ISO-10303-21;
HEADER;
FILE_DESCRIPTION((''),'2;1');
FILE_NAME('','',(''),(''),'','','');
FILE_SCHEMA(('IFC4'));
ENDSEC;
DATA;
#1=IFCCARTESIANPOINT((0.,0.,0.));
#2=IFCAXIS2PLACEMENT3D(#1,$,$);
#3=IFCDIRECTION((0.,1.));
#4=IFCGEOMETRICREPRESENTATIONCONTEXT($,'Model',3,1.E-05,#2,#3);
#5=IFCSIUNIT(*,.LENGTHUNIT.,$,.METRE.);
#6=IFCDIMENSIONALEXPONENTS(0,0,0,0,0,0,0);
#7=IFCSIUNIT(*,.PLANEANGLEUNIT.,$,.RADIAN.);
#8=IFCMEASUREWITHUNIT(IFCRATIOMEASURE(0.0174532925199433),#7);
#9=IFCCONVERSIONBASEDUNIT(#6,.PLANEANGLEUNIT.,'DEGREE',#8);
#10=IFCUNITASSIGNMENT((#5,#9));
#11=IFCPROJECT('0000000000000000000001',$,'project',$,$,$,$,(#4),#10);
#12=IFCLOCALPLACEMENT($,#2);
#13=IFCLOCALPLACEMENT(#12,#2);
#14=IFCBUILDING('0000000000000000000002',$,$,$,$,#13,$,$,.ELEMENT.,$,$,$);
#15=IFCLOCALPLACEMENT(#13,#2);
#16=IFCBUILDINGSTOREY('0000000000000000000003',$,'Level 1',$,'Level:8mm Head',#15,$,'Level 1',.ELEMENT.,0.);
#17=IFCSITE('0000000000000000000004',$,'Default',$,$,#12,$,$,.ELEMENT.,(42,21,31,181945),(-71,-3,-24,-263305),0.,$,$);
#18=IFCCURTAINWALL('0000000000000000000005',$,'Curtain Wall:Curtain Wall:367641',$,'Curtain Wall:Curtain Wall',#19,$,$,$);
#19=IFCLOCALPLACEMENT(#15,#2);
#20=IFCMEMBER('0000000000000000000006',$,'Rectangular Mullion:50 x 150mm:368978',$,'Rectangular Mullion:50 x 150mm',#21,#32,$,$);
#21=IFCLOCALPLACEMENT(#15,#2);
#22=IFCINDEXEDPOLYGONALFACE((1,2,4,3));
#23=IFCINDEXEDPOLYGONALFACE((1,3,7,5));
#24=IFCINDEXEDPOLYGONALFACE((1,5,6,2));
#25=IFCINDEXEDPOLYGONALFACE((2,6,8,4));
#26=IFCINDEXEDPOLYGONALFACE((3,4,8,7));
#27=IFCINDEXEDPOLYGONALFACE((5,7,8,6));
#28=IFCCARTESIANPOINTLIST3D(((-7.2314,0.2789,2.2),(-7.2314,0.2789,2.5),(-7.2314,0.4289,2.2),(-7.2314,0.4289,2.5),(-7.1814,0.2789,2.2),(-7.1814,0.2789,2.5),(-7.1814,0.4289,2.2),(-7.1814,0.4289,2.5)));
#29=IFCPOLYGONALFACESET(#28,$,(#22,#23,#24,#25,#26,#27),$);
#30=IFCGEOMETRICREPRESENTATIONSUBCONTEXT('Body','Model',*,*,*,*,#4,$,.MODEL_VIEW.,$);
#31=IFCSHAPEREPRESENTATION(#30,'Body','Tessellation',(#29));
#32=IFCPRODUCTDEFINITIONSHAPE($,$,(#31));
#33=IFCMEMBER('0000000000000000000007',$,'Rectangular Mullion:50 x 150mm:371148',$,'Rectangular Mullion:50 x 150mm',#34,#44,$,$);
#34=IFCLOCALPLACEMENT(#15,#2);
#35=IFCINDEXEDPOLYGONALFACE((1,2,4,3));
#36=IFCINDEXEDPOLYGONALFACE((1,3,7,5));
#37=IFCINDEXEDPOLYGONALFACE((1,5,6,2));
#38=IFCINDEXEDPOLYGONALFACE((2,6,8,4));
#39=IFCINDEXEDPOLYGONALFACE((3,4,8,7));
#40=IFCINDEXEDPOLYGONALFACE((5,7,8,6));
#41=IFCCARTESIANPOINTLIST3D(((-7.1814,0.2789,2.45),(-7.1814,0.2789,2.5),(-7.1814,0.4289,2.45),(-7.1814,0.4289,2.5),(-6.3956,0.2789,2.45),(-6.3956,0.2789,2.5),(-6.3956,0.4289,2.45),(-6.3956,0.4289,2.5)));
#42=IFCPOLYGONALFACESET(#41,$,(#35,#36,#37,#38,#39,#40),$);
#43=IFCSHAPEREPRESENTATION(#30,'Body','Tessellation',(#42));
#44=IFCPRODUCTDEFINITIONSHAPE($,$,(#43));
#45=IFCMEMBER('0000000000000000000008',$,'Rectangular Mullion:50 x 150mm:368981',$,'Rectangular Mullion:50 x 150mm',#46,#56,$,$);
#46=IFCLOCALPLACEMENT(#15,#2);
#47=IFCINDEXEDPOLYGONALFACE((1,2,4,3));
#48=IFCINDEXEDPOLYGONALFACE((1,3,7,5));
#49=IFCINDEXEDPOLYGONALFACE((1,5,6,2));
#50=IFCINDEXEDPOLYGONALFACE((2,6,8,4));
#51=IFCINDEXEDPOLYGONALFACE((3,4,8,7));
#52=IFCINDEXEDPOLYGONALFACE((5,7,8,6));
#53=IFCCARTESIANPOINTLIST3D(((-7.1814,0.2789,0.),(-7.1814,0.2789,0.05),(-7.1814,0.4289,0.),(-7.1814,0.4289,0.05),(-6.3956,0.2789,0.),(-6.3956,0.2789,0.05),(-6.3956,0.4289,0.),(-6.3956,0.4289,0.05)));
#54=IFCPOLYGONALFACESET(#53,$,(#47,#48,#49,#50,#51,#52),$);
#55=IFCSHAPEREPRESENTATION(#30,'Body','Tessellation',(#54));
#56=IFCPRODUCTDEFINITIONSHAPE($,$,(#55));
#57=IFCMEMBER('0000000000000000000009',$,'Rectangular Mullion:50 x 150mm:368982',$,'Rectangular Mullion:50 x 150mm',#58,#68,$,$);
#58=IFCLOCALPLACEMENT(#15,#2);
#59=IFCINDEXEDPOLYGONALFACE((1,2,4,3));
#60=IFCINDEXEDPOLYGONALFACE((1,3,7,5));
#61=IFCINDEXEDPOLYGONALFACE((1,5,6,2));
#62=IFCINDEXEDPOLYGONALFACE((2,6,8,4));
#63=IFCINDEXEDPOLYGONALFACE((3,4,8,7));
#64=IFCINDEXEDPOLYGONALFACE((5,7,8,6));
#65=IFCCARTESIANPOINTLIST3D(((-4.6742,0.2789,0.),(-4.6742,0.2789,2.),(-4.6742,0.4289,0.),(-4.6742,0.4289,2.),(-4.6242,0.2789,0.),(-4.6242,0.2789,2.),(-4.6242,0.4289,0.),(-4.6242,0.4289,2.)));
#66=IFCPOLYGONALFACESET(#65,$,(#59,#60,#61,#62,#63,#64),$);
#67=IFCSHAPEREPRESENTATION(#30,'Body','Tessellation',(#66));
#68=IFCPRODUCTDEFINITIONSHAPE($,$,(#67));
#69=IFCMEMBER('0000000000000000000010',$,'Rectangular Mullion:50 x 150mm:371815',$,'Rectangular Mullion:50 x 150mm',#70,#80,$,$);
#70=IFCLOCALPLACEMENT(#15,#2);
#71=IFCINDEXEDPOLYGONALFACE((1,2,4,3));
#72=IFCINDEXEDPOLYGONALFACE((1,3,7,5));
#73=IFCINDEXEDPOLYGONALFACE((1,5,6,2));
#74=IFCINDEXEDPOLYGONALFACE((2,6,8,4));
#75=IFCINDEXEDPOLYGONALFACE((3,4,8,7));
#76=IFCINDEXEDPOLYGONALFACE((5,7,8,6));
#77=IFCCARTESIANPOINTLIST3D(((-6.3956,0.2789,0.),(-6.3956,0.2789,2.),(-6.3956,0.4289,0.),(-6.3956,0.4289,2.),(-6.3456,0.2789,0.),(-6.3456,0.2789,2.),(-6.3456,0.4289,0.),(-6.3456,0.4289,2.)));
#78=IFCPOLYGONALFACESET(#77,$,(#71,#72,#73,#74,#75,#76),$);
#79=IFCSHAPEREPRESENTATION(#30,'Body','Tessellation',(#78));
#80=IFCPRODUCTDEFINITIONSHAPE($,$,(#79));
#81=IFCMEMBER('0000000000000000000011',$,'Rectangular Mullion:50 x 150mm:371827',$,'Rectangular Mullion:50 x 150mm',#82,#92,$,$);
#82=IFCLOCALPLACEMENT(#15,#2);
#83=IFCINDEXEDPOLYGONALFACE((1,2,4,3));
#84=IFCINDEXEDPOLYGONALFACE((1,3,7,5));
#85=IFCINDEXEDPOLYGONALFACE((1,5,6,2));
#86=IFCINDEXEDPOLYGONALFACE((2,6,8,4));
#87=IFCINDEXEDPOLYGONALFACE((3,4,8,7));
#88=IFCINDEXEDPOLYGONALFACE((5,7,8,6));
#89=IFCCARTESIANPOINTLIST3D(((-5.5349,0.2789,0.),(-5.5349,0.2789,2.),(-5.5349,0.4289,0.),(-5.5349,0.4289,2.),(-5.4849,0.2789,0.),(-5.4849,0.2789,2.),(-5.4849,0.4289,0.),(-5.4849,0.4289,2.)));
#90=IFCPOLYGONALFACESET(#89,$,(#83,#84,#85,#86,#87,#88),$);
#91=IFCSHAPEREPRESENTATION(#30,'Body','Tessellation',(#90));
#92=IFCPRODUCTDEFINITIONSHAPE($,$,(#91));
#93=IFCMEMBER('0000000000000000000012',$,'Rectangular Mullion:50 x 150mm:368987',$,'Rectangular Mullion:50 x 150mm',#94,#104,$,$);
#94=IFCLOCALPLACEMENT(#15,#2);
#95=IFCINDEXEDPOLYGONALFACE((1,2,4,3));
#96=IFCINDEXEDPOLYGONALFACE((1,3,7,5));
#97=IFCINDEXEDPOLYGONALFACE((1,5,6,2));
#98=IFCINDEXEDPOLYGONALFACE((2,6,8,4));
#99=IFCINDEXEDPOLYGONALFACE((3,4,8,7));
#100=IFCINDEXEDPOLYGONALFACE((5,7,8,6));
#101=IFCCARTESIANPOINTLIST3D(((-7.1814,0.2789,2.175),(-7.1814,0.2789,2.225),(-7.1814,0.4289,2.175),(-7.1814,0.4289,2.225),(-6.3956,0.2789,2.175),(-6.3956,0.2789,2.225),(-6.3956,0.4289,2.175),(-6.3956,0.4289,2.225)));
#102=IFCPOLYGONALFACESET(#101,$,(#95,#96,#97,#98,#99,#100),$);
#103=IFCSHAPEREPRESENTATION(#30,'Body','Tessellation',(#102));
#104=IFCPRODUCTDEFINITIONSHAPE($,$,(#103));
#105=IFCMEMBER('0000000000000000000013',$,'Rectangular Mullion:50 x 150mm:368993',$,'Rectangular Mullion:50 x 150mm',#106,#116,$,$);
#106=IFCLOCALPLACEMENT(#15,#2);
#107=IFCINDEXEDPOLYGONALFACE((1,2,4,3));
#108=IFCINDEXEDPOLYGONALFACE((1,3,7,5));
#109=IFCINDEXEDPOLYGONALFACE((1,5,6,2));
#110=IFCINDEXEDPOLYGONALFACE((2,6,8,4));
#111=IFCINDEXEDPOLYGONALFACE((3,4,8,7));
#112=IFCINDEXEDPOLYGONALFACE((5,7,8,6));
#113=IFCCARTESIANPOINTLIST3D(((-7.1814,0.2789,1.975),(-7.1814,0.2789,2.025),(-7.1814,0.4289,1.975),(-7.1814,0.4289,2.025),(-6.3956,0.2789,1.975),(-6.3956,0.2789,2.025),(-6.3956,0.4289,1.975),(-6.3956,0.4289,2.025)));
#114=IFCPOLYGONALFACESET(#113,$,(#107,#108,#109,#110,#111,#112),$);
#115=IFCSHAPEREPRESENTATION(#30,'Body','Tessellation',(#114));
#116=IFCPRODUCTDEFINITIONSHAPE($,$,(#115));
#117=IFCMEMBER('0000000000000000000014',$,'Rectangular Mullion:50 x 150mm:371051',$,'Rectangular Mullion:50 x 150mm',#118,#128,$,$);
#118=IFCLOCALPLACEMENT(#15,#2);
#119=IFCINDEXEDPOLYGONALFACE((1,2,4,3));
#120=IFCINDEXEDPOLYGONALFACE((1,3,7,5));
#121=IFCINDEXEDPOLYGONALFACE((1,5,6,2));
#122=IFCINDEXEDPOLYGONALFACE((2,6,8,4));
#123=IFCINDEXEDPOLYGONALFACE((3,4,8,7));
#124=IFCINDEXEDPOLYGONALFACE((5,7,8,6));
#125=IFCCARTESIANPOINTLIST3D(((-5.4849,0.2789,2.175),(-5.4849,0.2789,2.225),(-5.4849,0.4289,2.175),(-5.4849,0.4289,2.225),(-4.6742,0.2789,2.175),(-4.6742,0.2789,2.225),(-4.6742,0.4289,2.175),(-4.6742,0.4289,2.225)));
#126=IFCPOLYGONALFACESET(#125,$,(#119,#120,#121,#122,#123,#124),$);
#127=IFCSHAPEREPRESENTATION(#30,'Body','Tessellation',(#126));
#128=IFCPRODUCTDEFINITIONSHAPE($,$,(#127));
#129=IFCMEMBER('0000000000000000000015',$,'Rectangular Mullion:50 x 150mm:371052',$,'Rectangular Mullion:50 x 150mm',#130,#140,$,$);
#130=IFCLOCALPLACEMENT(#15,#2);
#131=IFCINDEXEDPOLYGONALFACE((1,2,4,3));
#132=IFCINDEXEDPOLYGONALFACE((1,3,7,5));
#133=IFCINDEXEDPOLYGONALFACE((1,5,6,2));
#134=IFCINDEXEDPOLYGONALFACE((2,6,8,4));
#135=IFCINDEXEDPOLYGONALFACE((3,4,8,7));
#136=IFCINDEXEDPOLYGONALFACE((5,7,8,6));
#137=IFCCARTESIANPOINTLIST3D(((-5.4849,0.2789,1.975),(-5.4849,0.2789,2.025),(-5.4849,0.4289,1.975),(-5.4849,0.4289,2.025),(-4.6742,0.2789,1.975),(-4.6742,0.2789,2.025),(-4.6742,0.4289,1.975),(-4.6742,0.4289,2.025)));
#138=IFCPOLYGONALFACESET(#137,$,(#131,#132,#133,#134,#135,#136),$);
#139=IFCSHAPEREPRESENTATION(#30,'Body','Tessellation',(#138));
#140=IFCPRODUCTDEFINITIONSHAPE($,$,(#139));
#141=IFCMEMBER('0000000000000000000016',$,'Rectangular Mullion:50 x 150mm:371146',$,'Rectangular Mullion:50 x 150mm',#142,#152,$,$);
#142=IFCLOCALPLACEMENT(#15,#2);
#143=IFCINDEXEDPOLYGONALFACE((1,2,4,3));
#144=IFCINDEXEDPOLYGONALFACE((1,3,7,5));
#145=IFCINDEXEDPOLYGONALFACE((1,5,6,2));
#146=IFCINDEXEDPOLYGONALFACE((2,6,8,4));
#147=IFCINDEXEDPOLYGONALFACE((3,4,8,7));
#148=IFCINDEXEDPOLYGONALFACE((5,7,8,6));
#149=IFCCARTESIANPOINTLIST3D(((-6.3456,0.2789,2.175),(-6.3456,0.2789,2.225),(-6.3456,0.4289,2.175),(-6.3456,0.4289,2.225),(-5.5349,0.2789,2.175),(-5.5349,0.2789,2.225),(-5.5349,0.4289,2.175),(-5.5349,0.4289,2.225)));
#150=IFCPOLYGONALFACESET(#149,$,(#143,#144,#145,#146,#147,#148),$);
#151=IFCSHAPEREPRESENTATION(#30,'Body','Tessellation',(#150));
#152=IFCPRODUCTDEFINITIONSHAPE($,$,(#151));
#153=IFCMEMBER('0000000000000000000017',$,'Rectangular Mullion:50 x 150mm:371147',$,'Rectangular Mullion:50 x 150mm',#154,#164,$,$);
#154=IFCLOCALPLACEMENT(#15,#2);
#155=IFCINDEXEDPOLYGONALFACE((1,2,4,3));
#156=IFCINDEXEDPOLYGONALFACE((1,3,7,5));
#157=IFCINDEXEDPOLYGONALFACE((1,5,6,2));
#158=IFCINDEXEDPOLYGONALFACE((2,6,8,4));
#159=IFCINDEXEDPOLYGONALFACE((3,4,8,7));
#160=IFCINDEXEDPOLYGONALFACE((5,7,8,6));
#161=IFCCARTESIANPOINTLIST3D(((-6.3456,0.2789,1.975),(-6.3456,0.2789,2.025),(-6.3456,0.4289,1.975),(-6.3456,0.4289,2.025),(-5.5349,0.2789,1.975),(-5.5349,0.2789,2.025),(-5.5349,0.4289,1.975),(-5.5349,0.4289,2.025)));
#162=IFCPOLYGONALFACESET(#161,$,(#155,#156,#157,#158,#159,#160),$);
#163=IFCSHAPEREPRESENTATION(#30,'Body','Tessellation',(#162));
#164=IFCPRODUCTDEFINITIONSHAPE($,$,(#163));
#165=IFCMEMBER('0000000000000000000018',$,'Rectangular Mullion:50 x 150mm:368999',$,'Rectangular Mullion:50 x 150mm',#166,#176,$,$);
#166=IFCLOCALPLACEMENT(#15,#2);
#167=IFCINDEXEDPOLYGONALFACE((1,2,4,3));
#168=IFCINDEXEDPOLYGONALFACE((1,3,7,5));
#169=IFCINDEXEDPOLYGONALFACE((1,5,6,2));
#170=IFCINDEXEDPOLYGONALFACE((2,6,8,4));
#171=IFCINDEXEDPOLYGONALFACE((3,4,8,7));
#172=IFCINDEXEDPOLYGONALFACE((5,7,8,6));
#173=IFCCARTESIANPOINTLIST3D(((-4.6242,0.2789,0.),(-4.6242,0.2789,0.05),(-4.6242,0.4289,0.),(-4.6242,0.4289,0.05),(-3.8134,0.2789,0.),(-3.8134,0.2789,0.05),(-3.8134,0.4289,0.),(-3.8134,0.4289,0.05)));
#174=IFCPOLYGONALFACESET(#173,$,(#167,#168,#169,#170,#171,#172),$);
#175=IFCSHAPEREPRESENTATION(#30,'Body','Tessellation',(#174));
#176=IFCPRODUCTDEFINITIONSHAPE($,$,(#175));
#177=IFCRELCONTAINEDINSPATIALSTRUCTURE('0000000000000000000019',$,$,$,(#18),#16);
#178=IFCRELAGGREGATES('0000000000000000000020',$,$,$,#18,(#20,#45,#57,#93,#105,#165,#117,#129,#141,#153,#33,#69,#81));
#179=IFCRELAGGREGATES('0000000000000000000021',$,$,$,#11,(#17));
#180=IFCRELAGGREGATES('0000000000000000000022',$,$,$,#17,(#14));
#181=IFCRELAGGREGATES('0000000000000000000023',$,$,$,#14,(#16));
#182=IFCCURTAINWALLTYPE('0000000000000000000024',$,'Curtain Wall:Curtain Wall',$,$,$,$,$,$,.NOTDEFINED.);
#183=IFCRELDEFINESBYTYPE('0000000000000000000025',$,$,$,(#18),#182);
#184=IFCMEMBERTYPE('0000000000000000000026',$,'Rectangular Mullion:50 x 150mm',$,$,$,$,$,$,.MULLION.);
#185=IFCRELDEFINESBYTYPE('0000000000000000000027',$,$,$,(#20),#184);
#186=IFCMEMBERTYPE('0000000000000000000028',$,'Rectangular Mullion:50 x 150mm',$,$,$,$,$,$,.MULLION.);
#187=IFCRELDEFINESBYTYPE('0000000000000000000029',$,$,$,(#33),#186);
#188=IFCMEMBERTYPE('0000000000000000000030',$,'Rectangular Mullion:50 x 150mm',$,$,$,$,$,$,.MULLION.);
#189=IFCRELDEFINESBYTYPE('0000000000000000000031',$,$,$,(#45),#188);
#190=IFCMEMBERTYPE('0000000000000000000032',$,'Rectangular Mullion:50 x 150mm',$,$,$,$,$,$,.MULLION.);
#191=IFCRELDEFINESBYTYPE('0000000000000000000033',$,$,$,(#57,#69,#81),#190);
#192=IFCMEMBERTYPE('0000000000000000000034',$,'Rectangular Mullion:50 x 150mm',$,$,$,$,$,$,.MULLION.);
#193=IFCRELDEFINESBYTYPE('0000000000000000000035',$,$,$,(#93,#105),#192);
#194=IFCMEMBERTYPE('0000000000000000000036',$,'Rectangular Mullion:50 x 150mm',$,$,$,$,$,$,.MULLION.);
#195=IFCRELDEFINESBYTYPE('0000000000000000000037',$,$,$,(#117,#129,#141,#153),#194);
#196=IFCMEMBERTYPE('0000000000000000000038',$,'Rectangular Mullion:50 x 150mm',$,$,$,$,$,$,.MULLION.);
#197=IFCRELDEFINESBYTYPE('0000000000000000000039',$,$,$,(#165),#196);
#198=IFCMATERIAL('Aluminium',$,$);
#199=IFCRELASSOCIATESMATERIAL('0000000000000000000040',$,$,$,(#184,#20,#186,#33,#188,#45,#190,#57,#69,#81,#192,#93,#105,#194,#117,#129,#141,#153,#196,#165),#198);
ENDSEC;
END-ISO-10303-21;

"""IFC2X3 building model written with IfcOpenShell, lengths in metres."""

from ifc_helpers import new_model, entity, si_unit, converted_unit, direction, frame, origin, origin_2d_with_axis, place, context, subcontext, project, spatial, rectangle, extrude, source, transform, mapped, material, type_object, type_shapes, element, aggregate, save


model = new_model("IFC2X3")

# Units and contexts
model_context = context("Model", 3, precision=1e-05, world=origin(), true_north=direction((0.0, 1.0)))
body_context = subcontext(model_context, "Body", "Model", "MODEL_VIEW")
ifc_project = project(units=[si_unit("LENGTHUNIT", "METRE"), converted_unit("PLANEANGLEUNIT", "DEGREE", entity("IfcRatioMeasure", 0.0174532925199433), si_unit("PLANEANGLEUNIT", "RADIAN"), dimensions=[0, 0, 0, 0, 0, 0, 0])], contexts=[model_context])

# Site, building, storey
site_placement = place(None, origin())
site = spatial("IfcSite", under=ifc_project, at=site_placement, Name="Default", CompositionType="ELEMENT", RefLatitude=(42, 21, 31, 181945), RefLongitude=(-71, -3, -24, -263305), RefElevation=0.0)
building_placement = place(site_placement, origin())
building = spatial("IfcBuilding", under=site, at=building_placement, CompositionType="ELEMENT")
storey_placement = place(building_placement, origin())
storey = spatial("IfcBuildingStorey", under=building, at=storey_placement, Name="Level 1", ObjectType="Level:8mm Head", LongName="Level 1", CompositionType="ELEMENT", Elevation=0.0)

# Curtain wall, members
curtain_wall_type = type_object("IfcCurtainWallType", Name="Curtain Wall:Curtain Wall", PredefinedType="NOTDEFINED")
curtain_wall_1_placement = place(storey_placement, origin())
curtain_wall_1 = element("IfcCurtainWall", 1, at=curtain_wall_1_placement, inside=storey, type_object=curtain_wall_type, Name="Curtain Wall:Curtain Wall:367641", ObjectType="Curtain Wall:Curtain Wall")
ifc_material_1 = material(Name="Aluminium")
member_type_1 = type_object("IfcMemberType", Name="Rectangular Mullion:50 x 150mm", PredefinedType="MULLION", material=ifc_material_1)
shared_shape_1 = source(origin(), body_context, "Body", "SweptSolid", [
    extrude(rectangle(XDim=0.15, YDim=0.05, at=origin_2d_with_axis()), frame((-0.025, 0.0, -0.3), z_axis=(0.0, 0.0, 1.0), x_axis=(0.0, -1.0, 0.0)), (0.0, 0.0, 1.0), 0.3),
])
type_shapes(member_type_1, [shared_shape_1])
member_1_placement = place(storey_placement, frame((-7.2314, 0.3539, 2.5), z_axis=(0.0, 0.0, 1.0), x_axis=(-1.0, 0.0, 0.0)))
member_1 = element("IfcMember", 2, at=member_1_placement, type_object=member_type_1, material=ifc_material_1, Name="Rectangular Mullion:50 x 150mm:368978", ObjectType="Rectangular Mullion:50 x 150mm", context=body_context, shape_type="MappedRepresentation", body=[
    mapped(shared_shape_1, transform((0.0, 0.0, 0.0), scale=1.0)),
])
member_type_2 = type_object("IfcMemberType", Name="Rectangular Mullion:50 x 150mm", PredefinedType="MULLION", material=ifc_material_1)
shared_shape_2 = source(origin(), body_context, "Body", "SweptSolid", [
    extrude(rectangle(XDim=0.15, YDim=0.05, at=origin_2d_with_axis()), frame((-0.025, 0.0, -0.7857), z_axis=(0.0, 0.0, 1.0), x_axis=(0.0, -1.0, 0.0)), (0.0, 0.0, 1.0), 0.7857),
])
type_shapes(member_type_2, [shared_shape_2])
member_2_placement = place(storey_placement, frame((-6.3956, 0.3539, 2.5), z_axis=(1.0, 0.0, 0.0), x_axis=(0.0, 0.0, 1.0)))
member_2 = element("IfcMember", 3, at=member_2_placement, type_object=member_type_2, material=ifc_material_1, Name="Rectangular Mullion:50 x 150mm:371148", ObjectType="Rectangular Mullion:50 x 150mm", context=body_context, shape_type="MappedRepresentation", body=[
    mapped(shared_shape_2, transform((0.0, 0.0, 0.0), scale=1.0)),
])
member_type_3 = type_object("IfcMemberType", Name="Rectangular Mullion:50 x 150mm", PredefinedType="MULLION", material=ifc_material_1)
shared_shape_3 = source(origin(), body_context, "Body", "SweptSolid", [
    extrude(rectangle(XDim=0.15, YDim=0.05, at=origin_2d_with_axis()), frame((-0.025, 0.0, -0.7857), z_axis=(0.0, 0.0, 1.0), x_axis=(0.0, -1.0, 0.0)), (0.0, 0.0, 1.0), 0.7857),
])
type_shapes(member_type_3, [shared_shape_3])
member_3_placement = place(storey_placement, frame((-7.1814, 0.3539, 0.0), z_axis=(-1.0, 0.0, 0.0), x_axis=(0.0, 0.0, -1.0)))
member_3 = element("IfcMember", 4, at=member_3_placement, type_object=member_type_3, material=ifc_material_1, Name="Rectangular Mullion:50 x 150mm:368981", ObjectType="Rectangular Mullion:50 x 150mm", context=body_context, shape_type="MappedRepresentation", body=[
    mapped(shared_shape_3, transform((0.0, 0.0, 0.0), scale=1.0)),
])
member_type_4 = type_object("IfcMemberType", Name="Rectangular Mullion:50 x 150mm", PredefinedType="MULLION", material=ifc_material_1)
shared_shape_4 = source(origin(), body_context, "Body", "SweptSolid", [
    extrude(rectangle(XDim=0.15, YDim=0.05, at=origin_2d_with_axis()), frame((0.0, 0.0, -2.0), z_axis=(0.0, 0.0, 1.0), x_axis=(0.0, -1.0, 0.0)), (0.0, 0.0, 1.0), 2.0),
])
type_shapes(member_type_4, [shared_shape_4])
member_4_placement = place(storey_placement, frame((-4.6492, 0.3539, 0.0), z_axis=(0.0, 0.0, -1.0), x_axis=(1.0, 0.0, 0.0)))
member_4 = element("IfcMember", 5, at=member_4_placement, type_object=member_type_4, material=ifc_material_1, Name="Rectangular Mullion:50 x 150mm:368982", ObjectType="Rectangular Mullion:50 x 150mm", context=body_context, shape_type="MappedRepresentation", body=[
    mapped(shared_shape_4, transform((0.0, 0.0, 0.0), scale=1.0)),
])
member_5_placement = place(storey_placement, frame((-6.3706, 0.3539, 0.0), z_axis=(0.0, 0.0, -1.0), x_axis=(1.0, 0.0, 0.0)))
member_5 = element("IfcMember", 6, at=member_5_placement, type_object=member_type_4, material=ifc_material_1, Name="Rectangular Mullion:50 x 150mm:371815", ObjectType="Rectangular Mullion:50 x 150mm", context=body_context, shape_type="MappedRepresentation", body=[
    mapped(shared_shape_4, transform((0.0, 0.0, 0.0), scale=1.0)),
])
member_6_placement = place(storey_placement, frame((-5.5099, 0.3539, 0.0), z_axis=(0.0, 0.0, -1.0), x_axis=(1.0, 0.0, 0.0)))
member_6 = element("IfcMember", 7, at=member_6_placement, type_object=member_type_4, material=ifc_material_1, Name="Rectangular Mullion:50 x 150mm:371827", ObjectType="Rectangular Mullion:50 x 150mm", context=body_context, shape_type="MappedRepresentation", body=[
    mapped(shared_shape_4, transform((0.0, 0.0, 0.0), scale=1.0)),
])
member_type_5 = type_object("IfcMemberType", Name="Rectangular Mullion:50 x 150mm", PredefinedType="MULLION", material=ifc_material_1)
shared_shape_5 = source(origin(), body_context, "Body", "SweptSolid", [
    extrude(rectangle(XDim=0.15, YDim=0.05, at=origin_2d_with_axis()), frame((0.0, 0.0, -0.7857), z_axis=(0.0, 0.0, 1.0), x_axis=(0.0, -1.0, 0.0)), (0.0, 0.0, 1.0), 0.7857),
])
type_shapes(member_type_5, [shared_shape_5])
member_7_placement = place(storey_placement, frame((-6.3956, 0.3539, 2.2), z_axis=(1.0, 0.0, 0.0), x_axis=(0.0, 0.0, 1.0)))
member_7 = element("IfcMember", 8, at=member_7_placement, type_object=member_type_5, material=ifc_material_1, Name="Rectangular Mullion:50 x 150mm:368987", ObjectType="Rectangular Mullion:50 x 150mm", context=body_context, shape_type="MappedRepresentation", body=[
    mapped(shared_shape_5, transform((0.0, 0.0, 0.0), scale=1.0)),
])
member_8_placement = place(storey_placement, frame((-6.3956, 0.3539, 2.0), z_axis=(1.0, 0.0, 0.0), x_axis=(0.0, 0.0, 1.0)))
member_8 = element("IfcMember", 9, at=member_8_placement, type_object=member_type_5, material=ifc_material_1, Name="Rectangular Mullion:50 x 150mm:368993", ObjectType="Rectangular Mullion:50 x 150mm", context=body_context, shape_type="MappedRepresentation", body=[
    mapped(shared_shape_5, transform((0.0, 0.0, 0.0), scale=1.0)),
])
member_type_6 = type_object("IfcMemberType", Name="Rectangular Mullion:50 x 150mm", PredefinedType="MULLION", material=ifc_material_1)
shared_shape_6 = source(origin(), body_context, "Body", "SweptSolid", [
    extrude(rectangle(XDim=0.15, YDim=0.05, at=origin_2d_with_axis()), frame((0.0, 0.0, -0.8107), z_axis=(0.0, 0.0, 1.0), x_axis=(0.0, -1.0, 0.0)), (0.0, 0.0, 1.0), 0.8107),
])
type_shapes(member_type_6, [shared_shape_6])
member_9_placement = place(storey_placement, frame((-4.6742, 0.3539, 2.2), z_axis=(1.0, 0.0, 0.0), x_axis=(0.0, 0.0, 1.0)))
member_9 = element("IfcMember", 10, at=member_9_placement, type_object=member_type_6, material=ifc_material_1, Name="Rectangular Mullion:50 x 150mm:371051", ObjectType="Rectangular Mullion:50 x 150mm", context=body_context, shape_type="MappedRepresentation", body=[
    mapped(shared_shape_6, transform((0.0, 0.0, 0.0), scale=1.0)),
])
member_10_placement = place(storey_placement, frame((-4.6742, 0.3539, 2.0), z_axis=(1.0, 0.0, 0.0), x_axis=(0.0, 0.0, 1.0)))
member_10 = element("IfcMember", 11, at=member_10_placement, type_object=member_type_6, material=ifc_material_1, Name="Rectangular Mullion:50 x 150mm:371052", ObjectType="Rectangular Mullion:50 x 150mm", context=body_context, shape_type="MappedRepresentation", body=[
    mapped(shared_shape_6, transform((0.0, 0.0, 0.0), scale=1.0)),
])
member_11_placement = place(storey_placement, frame((-5.5349, 0.3539, 2.2), z_axis=(1.0, 0.0, 0.0), x_axis=(0.0, 0.0, 1.0)))
member_11 = element("IfcMember", 12, at=member_11_placement, type_object=member_type_6, material=ifc_material_1, Name="Rectangular Mullion:50 x 150mm:371146", ObjectType="Rectangular Mullion:50 x 150mm", context=body_context, shape_type="MappedRepresentation", body=[
    mapped(shared_shape_6, transform((0.0, 0.0, 0.0), scale=1.0)),
])
member_12_placement = place(storey_placement, frame((-5.5349, 0.3539, 2.0), z_axis=(1.0, 0.0, 0.0), x_axis=(0.0, 0.0, 1.0)))
member_12 = element("IfcMember", 13, at=member_12_placement, type_object=member_type_6, material=ifc_material_1, Name="Rectangular Mullion:50 x 150mm:371147", ObjectType="Rectangular Mullion:50 x 150mm", context=body_context, shape_type="MappedRepresentation", body=[
    mapped(shared_shape_6, transform((0.0, 0.0, 0.0), scale=1.0)),
])
member_type_7 = type_object("IfcMemberType", Name="Rectangular Mullion:50 x 150mm", PredefinedType="MULLION", material=ifc_material_1)
shared_shape_7 = source(origin(), body_context, "Body", "SweptSolid", [
    extrude(rectangle(XDim=0.15, YDim=0.05, at=origin_2d_with_axis()), frame((-0.025, 0.0, -0.8107), z_axis=(0.0, 0.0, 1.0), x_axis=(0.0, -1.0, 0.0)), (0.0, 0.0, 1.0), 0.8107),
])
type_shapes(member_type_7, [shared_shape_7])
member_13_placement = place(storey_placement, frame((-4.6242, 0.3539, 0.0), z_axis=(-1.0, 0.0, 0.0), x_axis=(0.0, 0.0, -1.0)))
member_13 = element("IfcMember", 14, at=member_13_placement, type_object=member_type_7, material=ifc_material_1, Name="Rectangular Mullion:50 x 150mm:368999", ObjectType="Rectangular Mullion:50 x 150mm", context=body_context, shape_type="MappedRepresentation", body=[
    mapped(shared_shape_7, transform((0.0, 0.0, 0.0), scale=1.0)),
])

aggregate(curtain_wall_1, [member_1, member_3, member_4, member_7, member_8, member_13, member_9, member_10, member_11, member_12, member_2, member_5, member_6])

save(model, "model.ifc")
